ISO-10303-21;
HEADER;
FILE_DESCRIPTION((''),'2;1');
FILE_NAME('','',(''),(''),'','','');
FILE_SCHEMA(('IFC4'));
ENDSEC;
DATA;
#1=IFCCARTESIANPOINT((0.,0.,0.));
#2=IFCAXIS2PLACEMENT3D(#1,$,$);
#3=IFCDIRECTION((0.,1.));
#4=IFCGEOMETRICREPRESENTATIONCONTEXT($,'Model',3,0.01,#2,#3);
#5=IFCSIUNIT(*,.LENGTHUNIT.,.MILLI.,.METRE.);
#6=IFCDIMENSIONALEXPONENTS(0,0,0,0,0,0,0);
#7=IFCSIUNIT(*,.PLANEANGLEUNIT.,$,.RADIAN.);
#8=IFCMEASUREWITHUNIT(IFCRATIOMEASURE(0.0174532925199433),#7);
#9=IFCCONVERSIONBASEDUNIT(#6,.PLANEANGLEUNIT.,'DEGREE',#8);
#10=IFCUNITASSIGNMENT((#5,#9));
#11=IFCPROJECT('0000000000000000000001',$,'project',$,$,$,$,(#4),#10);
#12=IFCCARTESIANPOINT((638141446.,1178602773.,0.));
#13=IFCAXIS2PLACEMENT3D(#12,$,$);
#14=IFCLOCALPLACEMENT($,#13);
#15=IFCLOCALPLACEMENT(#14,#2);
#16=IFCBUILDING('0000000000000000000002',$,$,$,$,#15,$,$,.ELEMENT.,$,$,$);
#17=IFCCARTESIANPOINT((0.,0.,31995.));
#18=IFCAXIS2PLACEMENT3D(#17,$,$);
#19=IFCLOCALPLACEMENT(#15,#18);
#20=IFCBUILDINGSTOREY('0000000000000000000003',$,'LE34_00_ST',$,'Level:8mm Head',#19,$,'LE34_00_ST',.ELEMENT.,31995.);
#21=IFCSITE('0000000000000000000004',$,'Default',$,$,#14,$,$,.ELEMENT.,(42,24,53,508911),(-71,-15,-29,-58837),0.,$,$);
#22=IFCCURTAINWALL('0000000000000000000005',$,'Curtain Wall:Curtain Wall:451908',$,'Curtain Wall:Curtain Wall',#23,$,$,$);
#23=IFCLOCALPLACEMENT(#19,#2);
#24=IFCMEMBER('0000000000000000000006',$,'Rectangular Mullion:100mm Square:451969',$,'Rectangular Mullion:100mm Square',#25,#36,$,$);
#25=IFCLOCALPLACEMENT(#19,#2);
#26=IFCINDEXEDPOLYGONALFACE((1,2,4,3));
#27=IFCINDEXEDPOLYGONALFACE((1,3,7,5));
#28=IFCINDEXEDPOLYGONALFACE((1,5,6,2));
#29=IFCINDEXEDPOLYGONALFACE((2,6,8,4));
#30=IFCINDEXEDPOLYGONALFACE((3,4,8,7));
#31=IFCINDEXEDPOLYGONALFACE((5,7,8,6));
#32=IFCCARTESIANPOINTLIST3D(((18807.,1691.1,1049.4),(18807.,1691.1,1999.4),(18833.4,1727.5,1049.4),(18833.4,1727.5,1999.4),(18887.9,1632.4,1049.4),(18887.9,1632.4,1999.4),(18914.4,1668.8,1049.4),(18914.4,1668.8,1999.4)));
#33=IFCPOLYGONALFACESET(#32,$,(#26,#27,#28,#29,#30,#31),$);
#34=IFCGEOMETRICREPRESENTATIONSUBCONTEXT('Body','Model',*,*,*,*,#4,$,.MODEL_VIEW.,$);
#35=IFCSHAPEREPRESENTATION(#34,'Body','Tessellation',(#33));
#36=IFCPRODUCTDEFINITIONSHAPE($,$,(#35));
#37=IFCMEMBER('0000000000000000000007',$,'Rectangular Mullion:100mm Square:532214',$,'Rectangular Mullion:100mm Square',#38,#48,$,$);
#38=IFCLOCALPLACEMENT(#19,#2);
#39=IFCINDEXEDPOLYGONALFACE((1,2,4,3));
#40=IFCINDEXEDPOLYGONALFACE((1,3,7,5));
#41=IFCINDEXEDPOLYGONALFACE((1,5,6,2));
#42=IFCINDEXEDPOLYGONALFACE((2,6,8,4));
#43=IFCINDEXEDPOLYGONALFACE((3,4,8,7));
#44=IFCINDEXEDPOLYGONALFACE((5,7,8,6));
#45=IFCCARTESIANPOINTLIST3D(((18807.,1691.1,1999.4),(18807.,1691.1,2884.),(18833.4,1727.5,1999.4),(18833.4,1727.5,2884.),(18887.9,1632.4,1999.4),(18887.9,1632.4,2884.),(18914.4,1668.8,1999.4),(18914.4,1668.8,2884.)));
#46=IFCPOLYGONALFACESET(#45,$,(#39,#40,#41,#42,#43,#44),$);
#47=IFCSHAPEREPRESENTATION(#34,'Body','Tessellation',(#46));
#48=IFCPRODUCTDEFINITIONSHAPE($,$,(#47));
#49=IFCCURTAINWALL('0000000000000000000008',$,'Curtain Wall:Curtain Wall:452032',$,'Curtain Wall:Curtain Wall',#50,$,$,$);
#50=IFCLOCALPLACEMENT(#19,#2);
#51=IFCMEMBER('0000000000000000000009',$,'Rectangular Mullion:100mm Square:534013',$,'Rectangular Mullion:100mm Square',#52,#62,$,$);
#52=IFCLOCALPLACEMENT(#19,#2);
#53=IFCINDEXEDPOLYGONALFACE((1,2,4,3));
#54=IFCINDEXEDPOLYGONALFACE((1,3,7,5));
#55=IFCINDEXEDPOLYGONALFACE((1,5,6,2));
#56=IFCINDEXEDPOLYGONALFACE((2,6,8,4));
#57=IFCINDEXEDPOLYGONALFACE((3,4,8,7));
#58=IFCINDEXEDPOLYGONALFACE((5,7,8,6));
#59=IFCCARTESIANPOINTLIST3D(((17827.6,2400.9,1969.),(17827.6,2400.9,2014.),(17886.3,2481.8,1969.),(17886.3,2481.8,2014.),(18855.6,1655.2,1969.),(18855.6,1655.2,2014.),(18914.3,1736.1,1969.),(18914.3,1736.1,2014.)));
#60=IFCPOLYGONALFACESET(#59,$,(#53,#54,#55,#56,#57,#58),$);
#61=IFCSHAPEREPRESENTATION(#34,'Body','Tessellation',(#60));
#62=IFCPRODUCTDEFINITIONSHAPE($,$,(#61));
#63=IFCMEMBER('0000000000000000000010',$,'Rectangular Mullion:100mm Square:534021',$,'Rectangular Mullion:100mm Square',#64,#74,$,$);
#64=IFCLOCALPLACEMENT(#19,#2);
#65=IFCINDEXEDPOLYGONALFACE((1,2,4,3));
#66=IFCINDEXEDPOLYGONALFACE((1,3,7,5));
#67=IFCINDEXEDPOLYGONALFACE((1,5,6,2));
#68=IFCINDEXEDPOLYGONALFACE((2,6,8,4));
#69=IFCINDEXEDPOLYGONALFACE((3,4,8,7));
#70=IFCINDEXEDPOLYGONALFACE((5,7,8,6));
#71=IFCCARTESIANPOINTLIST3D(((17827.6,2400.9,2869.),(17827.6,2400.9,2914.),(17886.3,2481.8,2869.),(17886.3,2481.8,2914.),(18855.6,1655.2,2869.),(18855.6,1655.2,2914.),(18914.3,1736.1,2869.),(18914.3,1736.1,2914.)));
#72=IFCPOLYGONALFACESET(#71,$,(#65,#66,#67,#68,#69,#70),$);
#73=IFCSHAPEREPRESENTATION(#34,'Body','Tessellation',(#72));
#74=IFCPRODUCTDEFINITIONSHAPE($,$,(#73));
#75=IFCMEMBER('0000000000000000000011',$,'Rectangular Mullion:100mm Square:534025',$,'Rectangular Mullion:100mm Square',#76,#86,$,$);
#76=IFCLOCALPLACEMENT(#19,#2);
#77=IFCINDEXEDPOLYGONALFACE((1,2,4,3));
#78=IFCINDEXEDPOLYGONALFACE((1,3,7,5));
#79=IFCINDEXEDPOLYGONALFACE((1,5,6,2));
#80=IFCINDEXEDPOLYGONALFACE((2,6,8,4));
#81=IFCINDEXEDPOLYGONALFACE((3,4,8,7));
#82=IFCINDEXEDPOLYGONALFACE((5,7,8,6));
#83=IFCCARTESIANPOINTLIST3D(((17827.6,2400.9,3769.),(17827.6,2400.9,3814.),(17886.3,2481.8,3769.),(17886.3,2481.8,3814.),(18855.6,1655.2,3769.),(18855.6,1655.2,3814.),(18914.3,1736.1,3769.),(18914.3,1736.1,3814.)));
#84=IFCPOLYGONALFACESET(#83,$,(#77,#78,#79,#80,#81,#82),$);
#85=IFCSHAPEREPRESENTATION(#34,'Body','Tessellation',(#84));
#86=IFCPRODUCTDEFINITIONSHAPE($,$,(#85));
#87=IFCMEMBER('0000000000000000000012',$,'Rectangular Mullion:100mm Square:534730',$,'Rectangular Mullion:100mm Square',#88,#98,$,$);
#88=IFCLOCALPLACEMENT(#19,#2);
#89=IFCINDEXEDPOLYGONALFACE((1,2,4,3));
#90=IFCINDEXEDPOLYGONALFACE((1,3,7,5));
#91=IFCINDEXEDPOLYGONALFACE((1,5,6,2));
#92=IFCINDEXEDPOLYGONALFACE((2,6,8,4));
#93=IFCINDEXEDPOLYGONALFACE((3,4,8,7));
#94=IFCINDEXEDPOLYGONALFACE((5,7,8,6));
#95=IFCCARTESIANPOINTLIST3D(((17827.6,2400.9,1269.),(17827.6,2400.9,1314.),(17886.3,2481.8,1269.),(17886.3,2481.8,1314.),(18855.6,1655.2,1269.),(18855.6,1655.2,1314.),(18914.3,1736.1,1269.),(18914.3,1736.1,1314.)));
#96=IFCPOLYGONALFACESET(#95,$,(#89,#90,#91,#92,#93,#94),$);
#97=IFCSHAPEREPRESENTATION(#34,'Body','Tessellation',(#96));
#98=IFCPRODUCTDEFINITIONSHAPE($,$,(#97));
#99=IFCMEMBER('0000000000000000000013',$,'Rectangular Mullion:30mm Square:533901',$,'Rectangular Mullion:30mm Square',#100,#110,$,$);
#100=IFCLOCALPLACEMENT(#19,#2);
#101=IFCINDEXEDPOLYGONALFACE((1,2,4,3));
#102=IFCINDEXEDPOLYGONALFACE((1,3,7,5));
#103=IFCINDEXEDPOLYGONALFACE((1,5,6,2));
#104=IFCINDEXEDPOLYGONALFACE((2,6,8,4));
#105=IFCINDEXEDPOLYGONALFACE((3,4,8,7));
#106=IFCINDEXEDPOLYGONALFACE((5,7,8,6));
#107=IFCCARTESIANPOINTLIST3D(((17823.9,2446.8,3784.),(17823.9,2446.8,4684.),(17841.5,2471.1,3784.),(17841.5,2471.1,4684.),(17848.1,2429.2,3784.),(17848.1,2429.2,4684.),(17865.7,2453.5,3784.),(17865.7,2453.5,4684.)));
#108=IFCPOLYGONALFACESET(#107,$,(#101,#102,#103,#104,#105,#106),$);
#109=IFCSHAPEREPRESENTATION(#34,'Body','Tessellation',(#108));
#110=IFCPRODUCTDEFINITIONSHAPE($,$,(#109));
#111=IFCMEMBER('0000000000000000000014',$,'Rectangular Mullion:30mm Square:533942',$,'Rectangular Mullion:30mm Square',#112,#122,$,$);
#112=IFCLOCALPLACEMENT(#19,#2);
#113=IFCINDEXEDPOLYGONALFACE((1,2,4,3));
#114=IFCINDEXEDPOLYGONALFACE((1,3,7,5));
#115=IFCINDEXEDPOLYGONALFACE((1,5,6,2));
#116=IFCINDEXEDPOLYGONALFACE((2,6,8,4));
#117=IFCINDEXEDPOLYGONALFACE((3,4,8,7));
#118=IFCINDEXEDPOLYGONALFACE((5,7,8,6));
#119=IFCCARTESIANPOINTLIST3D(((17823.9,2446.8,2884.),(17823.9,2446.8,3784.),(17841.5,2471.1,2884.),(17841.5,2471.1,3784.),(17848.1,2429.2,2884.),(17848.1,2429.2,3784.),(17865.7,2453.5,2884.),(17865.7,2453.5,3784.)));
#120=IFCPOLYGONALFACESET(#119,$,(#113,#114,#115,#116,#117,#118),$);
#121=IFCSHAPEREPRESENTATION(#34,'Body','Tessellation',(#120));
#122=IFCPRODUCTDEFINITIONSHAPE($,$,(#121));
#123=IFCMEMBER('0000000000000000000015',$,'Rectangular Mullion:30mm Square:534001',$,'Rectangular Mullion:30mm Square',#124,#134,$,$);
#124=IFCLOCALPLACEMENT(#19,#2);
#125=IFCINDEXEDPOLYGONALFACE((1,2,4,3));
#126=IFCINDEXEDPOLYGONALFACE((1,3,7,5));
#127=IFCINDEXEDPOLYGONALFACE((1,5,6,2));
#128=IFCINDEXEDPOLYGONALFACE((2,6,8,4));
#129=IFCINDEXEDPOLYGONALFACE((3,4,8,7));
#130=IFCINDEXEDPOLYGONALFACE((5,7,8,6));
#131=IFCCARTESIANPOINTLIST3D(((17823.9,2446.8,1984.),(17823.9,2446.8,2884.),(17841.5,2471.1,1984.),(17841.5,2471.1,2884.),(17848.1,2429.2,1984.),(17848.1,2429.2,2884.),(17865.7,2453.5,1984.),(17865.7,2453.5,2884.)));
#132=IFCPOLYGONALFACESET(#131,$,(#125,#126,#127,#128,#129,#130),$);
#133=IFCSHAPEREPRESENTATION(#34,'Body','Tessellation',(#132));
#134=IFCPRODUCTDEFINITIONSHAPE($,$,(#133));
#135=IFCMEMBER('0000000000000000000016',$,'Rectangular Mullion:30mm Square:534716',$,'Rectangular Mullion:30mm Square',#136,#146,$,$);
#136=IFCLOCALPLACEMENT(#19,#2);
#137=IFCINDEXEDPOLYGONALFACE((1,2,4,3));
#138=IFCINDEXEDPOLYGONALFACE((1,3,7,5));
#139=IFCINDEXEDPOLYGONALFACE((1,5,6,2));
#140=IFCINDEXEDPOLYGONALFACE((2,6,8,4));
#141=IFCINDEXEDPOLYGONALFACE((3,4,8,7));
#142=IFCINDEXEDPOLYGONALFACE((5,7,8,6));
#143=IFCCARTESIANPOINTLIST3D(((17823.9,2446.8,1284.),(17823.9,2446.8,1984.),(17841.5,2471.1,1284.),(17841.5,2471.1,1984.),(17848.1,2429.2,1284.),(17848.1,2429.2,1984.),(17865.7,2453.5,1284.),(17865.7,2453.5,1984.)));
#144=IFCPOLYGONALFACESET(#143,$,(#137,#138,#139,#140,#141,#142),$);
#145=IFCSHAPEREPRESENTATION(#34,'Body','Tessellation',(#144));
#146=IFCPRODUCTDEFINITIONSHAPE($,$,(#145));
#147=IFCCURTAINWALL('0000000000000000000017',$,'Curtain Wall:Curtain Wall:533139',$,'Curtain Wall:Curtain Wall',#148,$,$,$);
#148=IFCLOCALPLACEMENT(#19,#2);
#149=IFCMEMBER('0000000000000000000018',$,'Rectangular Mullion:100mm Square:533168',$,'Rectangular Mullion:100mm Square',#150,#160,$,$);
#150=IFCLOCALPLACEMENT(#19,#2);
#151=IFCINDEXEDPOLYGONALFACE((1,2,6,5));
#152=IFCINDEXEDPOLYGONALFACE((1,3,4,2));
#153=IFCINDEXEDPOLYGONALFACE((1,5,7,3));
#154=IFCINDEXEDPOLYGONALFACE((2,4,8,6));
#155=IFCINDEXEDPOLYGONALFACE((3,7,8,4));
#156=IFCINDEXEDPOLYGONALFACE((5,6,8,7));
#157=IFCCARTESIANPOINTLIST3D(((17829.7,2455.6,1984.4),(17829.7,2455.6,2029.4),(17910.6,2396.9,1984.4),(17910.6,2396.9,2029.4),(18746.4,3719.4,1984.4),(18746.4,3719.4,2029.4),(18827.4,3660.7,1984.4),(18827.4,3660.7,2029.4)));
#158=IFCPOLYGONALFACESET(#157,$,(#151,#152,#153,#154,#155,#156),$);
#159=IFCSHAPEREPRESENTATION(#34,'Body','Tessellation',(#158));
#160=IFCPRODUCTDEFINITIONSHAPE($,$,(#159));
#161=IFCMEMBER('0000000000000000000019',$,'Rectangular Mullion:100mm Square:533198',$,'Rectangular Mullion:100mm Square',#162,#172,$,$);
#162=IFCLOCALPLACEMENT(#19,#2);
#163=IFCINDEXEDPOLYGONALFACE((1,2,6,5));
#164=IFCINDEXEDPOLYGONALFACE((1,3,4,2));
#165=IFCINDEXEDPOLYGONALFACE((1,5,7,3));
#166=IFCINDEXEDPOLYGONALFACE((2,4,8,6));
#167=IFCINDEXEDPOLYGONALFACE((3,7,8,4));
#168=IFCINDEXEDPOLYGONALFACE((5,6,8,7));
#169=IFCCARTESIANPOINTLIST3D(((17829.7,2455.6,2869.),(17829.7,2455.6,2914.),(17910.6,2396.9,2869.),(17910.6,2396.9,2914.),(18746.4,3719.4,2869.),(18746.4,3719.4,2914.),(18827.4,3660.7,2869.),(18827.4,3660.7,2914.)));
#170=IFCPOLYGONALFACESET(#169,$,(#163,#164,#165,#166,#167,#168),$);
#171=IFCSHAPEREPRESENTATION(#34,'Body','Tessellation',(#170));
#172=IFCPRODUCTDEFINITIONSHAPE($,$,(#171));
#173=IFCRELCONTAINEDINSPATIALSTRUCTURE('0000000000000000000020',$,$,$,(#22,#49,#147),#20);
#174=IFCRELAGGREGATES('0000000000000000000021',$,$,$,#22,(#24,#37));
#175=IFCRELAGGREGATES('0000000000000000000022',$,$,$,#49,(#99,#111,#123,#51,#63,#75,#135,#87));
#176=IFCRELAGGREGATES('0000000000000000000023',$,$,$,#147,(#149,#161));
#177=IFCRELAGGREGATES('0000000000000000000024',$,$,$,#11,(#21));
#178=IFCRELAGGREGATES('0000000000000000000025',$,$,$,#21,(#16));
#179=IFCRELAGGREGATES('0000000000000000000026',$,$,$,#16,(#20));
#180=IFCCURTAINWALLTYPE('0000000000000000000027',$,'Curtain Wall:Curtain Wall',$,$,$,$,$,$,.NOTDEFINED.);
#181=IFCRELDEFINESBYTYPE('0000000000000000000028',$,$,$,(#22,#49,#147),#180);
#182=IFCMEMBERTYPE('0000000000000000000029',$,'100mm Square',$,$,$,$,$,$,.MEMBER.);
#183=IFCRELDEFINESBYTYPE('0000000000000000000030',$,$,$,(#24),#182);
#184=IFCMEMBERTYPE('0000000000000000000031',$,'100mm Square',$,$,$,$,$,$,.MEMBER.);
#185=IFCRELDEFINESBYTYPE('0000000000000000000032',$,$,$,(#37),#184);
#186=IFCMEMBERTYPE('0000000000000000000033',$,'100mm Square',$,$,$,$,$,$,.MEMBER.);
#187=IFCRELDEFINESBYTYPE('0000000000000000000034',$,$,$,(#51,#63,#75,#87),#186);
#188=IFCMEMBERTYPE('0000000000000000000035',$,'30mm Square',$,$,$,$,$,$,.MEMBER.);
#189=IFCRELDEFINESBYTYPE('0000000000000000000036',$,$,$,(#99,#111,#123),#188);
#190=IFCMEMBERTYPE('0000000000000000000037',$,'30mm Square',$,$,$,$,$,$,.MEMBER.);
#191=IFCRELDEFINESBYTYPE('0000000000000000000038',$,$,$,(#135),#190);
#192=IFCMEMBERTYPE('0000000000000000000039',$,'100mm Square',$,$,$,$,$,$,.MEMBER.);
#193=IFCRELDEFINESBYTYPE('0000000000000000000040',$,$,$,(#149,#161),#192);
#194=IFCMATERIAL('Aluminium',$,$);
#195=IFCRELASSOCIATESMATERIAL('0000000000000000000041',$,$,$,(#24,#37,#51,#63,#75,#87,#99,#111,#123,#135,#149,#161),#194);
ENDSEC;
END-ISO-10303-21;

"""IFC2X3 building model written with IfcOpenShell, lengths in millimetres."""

from ifc_helpers import new_model, entity, si_unit, converted_unit, direction, frame, origin, origin_2d_with_axis, place, context, subcontext, project, spatial, rectangle, extrude, source, transform, mapped, material, type_object, type_shapes, element, aggregate, save


model = new_model("IFC2X3")

# Units and contexts
model_context = context("Model", 3, precision=0.01, world=origin(), true_north=direction((0.0, 1.0)))
body_context = subcontext(model_context, "Body", "Model", "MODEL_VIEW")
ifc_project = project(units=[si_unit("LENGTHUNIT", "METRE", prefix="MILLI"), converted_unit("PLANEANGLEUNIT", "DEGREE", entity("IfcRatioMeasure", 0.0174532925199433), si_unit("PLANEANGLEUNIT", "RADIAN"), dimensions=[0, 0, 0, 0, 0, 0, 0])], contexts=[model_context])

# Site, building, storey
site_placement = place(None, frame((638141446.0, 1178602773.0, 0.0)))
site = spatial("IfcSite", under=ifc_project, at=site_placement, Name="Default", CompositionType="ELEMENT", RefLatitude=(42, 24, 53, 508911), RefLongitude=(-71, -15, -29, -58837), RefElevation=0.0)
building_placement = place(site_placement, origin())
building = spatial("IfcBuilding", under=site, at=building_placement, CompositionType="ELEMENT")
storey_placement = place(building_placement, frame((0.0, 0.0, 31995.0)))
storey = spatial("IfcBuildingStorey", under=building, at=storey_placement, Name="LE34_00_ST", ObjectType="Level:8mm Head", LongName="LE34_00_ST", CompositionType="ELEMENT", Elevation=31995.0)

# Curtain walls, members
curtain_wall_type = type_object("IfcCurtainWallType", Name="Curtain Wall:Curtain Wall", PredefinedType="NOTDEFINED")
curtain_wall_1_placement = place(storey_placement, frame((0.0, 0.0, -31995.0)))
curtain_wall_1 = element("IfcCurtainWall", 1, at=curtain_wall_1_placement, inside=storey, type_object=curtain_wall_type, Name="Curtain Wall:Curtain Wall:451908", ObjectType="Curtain Wall:Curtain Wall")
ifc_material_1 = material(Name="Aluminium")
member_type_1 = type_object("IfcMemberType", Name="100mm Square", PredefinedType="MEMBER")
shared_shape_1 = source(origin(), body_context, "Body", "SweptSolid", [
    extrude(rectangle(XDim=100.0, YDim=45.0, at=origin_2d_with_axis()), frame((-22.5, 0.0, -950.0), z_axis=(0.0, 0.0, 1.0), x_axis=(0.0, -1.0, 0.0)), (0.0, 0.0, 1.0), 950.0),
])
type_shapes(member_type_1, [shared_shape_1])
member_1_placement = place(storey_placement, frame((18847.5, 1661.7, 1999.4), z_axis=(0.0, 0.0, 1.0), x_axis=(-0.587164, -0.809468, 0.0)))
member_1 = element("IfcMember", 2, at=member_1_placement, type_object=member_type_1, material=ifc_material_1, Name="Rectangular Mullion:100mm Square:451969", ObjectType="Rectangular Mullion:100mm Square", context=body_context, shape_type="MappedRepresentation", body=[
    mapped(shared_shape_1, transform((0.0, 0.0, 0.0), scale=1.0)),
])
member_type_2 = type_object("IfcMemberType", Name="100mm Square", PredefinedType="MEMBER")
shared_shape_2 = source(origin(), body_context, "Body", "SweptSolid", [
    extrude(rectangle(XDim=100.0, YDim=45.0, at=origin_2d_with_axis()), frame((-22.5, 0.0, -884.6), z_axis=(0.0, 0.0, 1.0), x_axis=(0.0, -1.0, 0.0)), (0.0, 0.0, 1.0), 884.6),
])
type_shapes(member_type_2, [shared_shape_2])
member_2_placement = place(storey_placement, frame((18847.5, 1661.7, 2884.0), z_axis=(0.0, 0.0, 1.0), x_axis=(-0.587164, -0.809468, 0.0)))
member_2 = element("IfcMember", 3, at=member_2_placement, type_object=member_type_2, material=ifc_material_1, Name="Rectangular Mullion:100mm Square:532214", ObjectType="Rectangular Mullion:100mm Square", context=body_context, shape_type="MappedRepresentation", body=[
    mapped(shared_shape_2, transform((0.0, 0.0, 0.0), scale=1.0)),
])
aggregate(curtain_wall_1, [member_1, member_2])
curtain_wall_2_placement = place(storey_placement, frame((0.0, 0.0, -31995.0)))
curtain_wall_2 = element("IfcCurtainWall", 4, at=curtain_wall_2_placement, inside=storey, type_object=curtain_wall_type, Name="Curtain Wall:Curtain Wall:452032", ObjectType="Curtain Wall:Curtain Wall")
member_type_3 = type_object("IfcMemberType", Name="100mm Square", PredefinedType="MEMBER")
shared_shape_3 = source(origin(), body_context, "Body", "SweptSolid", [
    extrude(rectangle(XDim=100.0, YDim=45.0, at=origin_2d_with_axis()), frame((7.5, 0.0, -1270.0), z_axis=(0.0, 0.0, 1.0), x_axis=(0.0, -1.0, 0.0)), (0.0, 0.0, 1.0), 1270.0),
])
type_shapes(member_type_3, [shared_shape_3])
member_3_placement = place(storey_placement, frame((17856.9, 2441.4, 1984.0), z_axis=(-0.809468, 0.587164, 0.0), x_axis=(0.0, 0.0, 1.0)))
member_3 = element("IfcMember", 5, at=member_3_placement, type_object=member_type_3, material=ifc_material_1, Name="Rectangular Mullion:100mm Square:534013", ObjectType="Rectangular Mullion:100mm Square", context=body_context, shape_type="MappedRepresentation", body=[
    mapped(shared_shape_3, transform((0.0, 0.0, 0.0), scale=1.0)),
])
member_4_placement = place(storey_placement, frame((17856.9, 2441.4, 2884.0), z_axis=(-0.809468, 0.587164, 0.0), x_axis=(0.0, 0.0, 1.0)))
member_4 = element("IfcMember", 6, at=member_4_placement, type_object=member_type_3, material=ifc_material_1, Name="Rectangular Mullion:100mm Square:534021", ObjectType="Rectangular Mullion:100mm Square", context=body_context, shape_type="MappedRepresentation", body=[
    mapped(shared_shape_3, transform((0.0, 0.0, 0.0), scale=1.0)),
])
member_5_placement = place(storey_placement, frame((17856.9, 2441.4, 3784.0), z_axis=(-0.809468, 0.587164, 0.0), x_axis=(0.0, 0.0, 1.0)))
member_5 = element("IfcMember", 7, at=member_5_placement, type_object=member_type_3, material=ifc_material_1, Name="Rectangular Mullion:100mm Square:534025", ObjectType="Rectangular Mullion:100mm Square", context=body_context, shape_type="MappedRepresentation", body=[
    mapped(shared_shape_3, transform((0.0, 0.0, 0.0), scale=1.0)),
])
member_6_placement = place(storey_placement, frame((17856.9, 2441.4, 1284.0), z_axis=(-0.809468, 0.587164, 0.0), x_axis=(0.0, 0.0, 1.0)))
member_6 = element("IfcMember", 8, at=member_6_placement, type_object=member_type_3, material=ifc_material_1, Name="Rectangular Mullion:100mm Square:534730", ObjectType="Rectangular Mullion:100mm Square", context=body_context, shape_type="MappedRepresentation", body=[
    mapped(shared_shape_3, transform((0.0, 0.0, 0.0), scale=1.0)),
])
member_type_4 = type_object("IfcMemberType", Name="30mm Square", PredefinedType="MEMBER")
shared_shape_4 = source(origin(), body_context, "Body", "SweptSolid", [
    extrude(rectangle(XDim=30.0, YDim=30.0, at=origin_2d_with_axis()), frame((-15.0, 0.0, -900.0), z_axis=(0.0, 0.0, 1.0), x_axis=(0.0, -1.0, 0.0)), (0.0, 0.0, 1.0), 900.0),
])
type_shapes(member_type_4, [shared_shape_4])
member_7_placement = place(storey_placement, frame((17832.7, 2459.0, 3784.0), z_axis=(0.0, 0.0, -1.0), x_axis=(-0.809468, 0.587164, 0.0)))
member_7 = element("IfcMember", 9, at=member_7_placement, type_object=member_type_4, material=ifc_material_1, Name="Rectangular Mullion:30mm Square:533901", ObjectType="Rectangular Mullion:30mm Square", context=body_context, shape_type="MappedRepresentation", body=[
    mapped(shared_shape_4, transform((0.0, 0.0, 0.0), scale=1.0)),
])
member_8_placement = place(storey_placement, frame((17832.7, 2459.0, 2884.0), z_axis=(0.0, 0.0, -1.0), x_axis=(-0.809468, 0.587164, 0.0)))
member_8 = element("IfcMember", 10, at=member_8_placement, type_object=member_type_4, material=ifc_material_1, Name="Rectangular Mullion:30mm Square:533942", ObjectType="Rectangular Mullion:30mm Square", context=body_context, shape_type="MappedRepresentation", body=[
    mapped(shared_shape_4, transform((0.0, 0.0, 0.0), scale=1.0)),
])
member_9_placement = place(storey_placement, frame((17832.7, 2459.0, 1984.0), z_axis=(0.0, 0.0, -1.0), x_axis=(-0.809468, 0.587164, 0.0)))
member_9 = element("IfcMember", 11, at=member_9_placement, type_object=member_type_4, material=ifc_material_1, Name="Rectangular Mullion:30mm Square:534001", ObjectType="Rectangular Mullion:30mm Square", context=body_context, shape_type="MappedRepresentation", body=[
    mapped(shared_shape_4, transform((0.0, 0.0, 0.0), scale=1.0)),
])
member_type_5 = type_object("IfcMemberType", Name="30mm Square", PredefinedType="MEMBER")
shared_shape_5 = source(origin(), body_context, "Body", "SweptSolid", [
    extrude(rectangle(XDim=30.0, YDim=30.0, at=origin_2d_with_axis()), frame((-15.0, 0.0, -700.0), z_axis=(0.0, 0.0, 1.0), x_axis=(0.0, -1.0, 0.0)), (0.0, 0.0, 1.0), 700.0),
])
type_shapes(member_type_5, [shared_shape_5])
member_10_placement = place(storey_placement, frame((17832.7, 2459.0, 1284.0), z_axis=(0.0, 0.0, -1.0), x_axis=(-0.809468, 0.587164, 0.0)))
member_10 = element("IfcMember", 12, at=member_10_placement, type_object=member_type_5, material=ifc_material_1, Name="Rectangular Mullion:30mm Square:534716", ObjectType="Rectangular Mullion:30mm Square", context=body_context, shape_type="MappedRepresentation", body=[
    mapped(shared_shape_5, transform((0.0, 0.0, 0.0), scale=1.0)),
])
curtain_wall_3_placement = place(storey_placement, frame((0.0, 0.0, -31995.0)))
curtain_wall_3 = element("IfcCurtainWall", 13, at=curtain_wall_3_placement, inside=storey, type_object=curtain_wall_type, Name="Curtain Wall:Curtain Wall:533139", ObjectType="Curtain Wall:Curtain Wall")
member_type_6 = type_object("IfcMemberType", Name="100mm Square", PredefinedType="MEMBER")
shared_shape_6 = source(origin(), body_context, "Body", "SweptSolid", [
    extrude(rectangle(XDim=100.0, YDim=45.0, at=origin_2d_with_axis()), frame((7.5, 0.0, -1561.3), z_axis=(0.0, 0.0, 1.0), x_axis=(0.0, -1.0, 0.0)), (0.0, 0.0, 1.0), 1561.3),
])
type_shapes(member_type_6, [shared_shape_6])
member_11_placement = place(storey_placement, frame((18786.9, 3690.0, 1999.4), z_axis=(0.587164, 0.809468, 0.0), x_axis=(0.0, 0.0, 1.0)))
member_11 = element("IfcMember", 14, at=member_11_placement, type_object=member_type_6, material=ifc_material_1, Name="Rectangular Mullion:100mm Square:533168", ObjectType="Rectangular Mullion:100mm Square", context=body_context, shape_type="MappedRepresentation", body=[
    mapped(shared_shape_6, transform((0.0, 0.0, 0.0), scale=1.0)),
])
member_12_placement = place(storey_placement, frame((18786.9, 3690.0, 2884.0), z_axis=(0.587164, 0.809468, 0.0), x_axis=(0.0, 0.0, 1.0)))
member_12 = element("IfcMember", 15, at=member_12_placement, type_object=member_type_6, material=ifc_material_1, Name="Rectangular Mullion:100mm Square:533198", ObjectType="Rectangular Mullion:100mm Square", context=body_context, shape_type="MappedRepresentation", body=[
    mapped(shared_shape_6, transform((0.0, 0.0, 0.0), scale=1.0)),
])

aggregate(curtain_wall_2, [member_7, member_8, member_9, member_3, member_4, member_5, member_10, member_6])
aggregate(curtain_wall_3, [member_11, member_12])

save(model, "model.ifc")
